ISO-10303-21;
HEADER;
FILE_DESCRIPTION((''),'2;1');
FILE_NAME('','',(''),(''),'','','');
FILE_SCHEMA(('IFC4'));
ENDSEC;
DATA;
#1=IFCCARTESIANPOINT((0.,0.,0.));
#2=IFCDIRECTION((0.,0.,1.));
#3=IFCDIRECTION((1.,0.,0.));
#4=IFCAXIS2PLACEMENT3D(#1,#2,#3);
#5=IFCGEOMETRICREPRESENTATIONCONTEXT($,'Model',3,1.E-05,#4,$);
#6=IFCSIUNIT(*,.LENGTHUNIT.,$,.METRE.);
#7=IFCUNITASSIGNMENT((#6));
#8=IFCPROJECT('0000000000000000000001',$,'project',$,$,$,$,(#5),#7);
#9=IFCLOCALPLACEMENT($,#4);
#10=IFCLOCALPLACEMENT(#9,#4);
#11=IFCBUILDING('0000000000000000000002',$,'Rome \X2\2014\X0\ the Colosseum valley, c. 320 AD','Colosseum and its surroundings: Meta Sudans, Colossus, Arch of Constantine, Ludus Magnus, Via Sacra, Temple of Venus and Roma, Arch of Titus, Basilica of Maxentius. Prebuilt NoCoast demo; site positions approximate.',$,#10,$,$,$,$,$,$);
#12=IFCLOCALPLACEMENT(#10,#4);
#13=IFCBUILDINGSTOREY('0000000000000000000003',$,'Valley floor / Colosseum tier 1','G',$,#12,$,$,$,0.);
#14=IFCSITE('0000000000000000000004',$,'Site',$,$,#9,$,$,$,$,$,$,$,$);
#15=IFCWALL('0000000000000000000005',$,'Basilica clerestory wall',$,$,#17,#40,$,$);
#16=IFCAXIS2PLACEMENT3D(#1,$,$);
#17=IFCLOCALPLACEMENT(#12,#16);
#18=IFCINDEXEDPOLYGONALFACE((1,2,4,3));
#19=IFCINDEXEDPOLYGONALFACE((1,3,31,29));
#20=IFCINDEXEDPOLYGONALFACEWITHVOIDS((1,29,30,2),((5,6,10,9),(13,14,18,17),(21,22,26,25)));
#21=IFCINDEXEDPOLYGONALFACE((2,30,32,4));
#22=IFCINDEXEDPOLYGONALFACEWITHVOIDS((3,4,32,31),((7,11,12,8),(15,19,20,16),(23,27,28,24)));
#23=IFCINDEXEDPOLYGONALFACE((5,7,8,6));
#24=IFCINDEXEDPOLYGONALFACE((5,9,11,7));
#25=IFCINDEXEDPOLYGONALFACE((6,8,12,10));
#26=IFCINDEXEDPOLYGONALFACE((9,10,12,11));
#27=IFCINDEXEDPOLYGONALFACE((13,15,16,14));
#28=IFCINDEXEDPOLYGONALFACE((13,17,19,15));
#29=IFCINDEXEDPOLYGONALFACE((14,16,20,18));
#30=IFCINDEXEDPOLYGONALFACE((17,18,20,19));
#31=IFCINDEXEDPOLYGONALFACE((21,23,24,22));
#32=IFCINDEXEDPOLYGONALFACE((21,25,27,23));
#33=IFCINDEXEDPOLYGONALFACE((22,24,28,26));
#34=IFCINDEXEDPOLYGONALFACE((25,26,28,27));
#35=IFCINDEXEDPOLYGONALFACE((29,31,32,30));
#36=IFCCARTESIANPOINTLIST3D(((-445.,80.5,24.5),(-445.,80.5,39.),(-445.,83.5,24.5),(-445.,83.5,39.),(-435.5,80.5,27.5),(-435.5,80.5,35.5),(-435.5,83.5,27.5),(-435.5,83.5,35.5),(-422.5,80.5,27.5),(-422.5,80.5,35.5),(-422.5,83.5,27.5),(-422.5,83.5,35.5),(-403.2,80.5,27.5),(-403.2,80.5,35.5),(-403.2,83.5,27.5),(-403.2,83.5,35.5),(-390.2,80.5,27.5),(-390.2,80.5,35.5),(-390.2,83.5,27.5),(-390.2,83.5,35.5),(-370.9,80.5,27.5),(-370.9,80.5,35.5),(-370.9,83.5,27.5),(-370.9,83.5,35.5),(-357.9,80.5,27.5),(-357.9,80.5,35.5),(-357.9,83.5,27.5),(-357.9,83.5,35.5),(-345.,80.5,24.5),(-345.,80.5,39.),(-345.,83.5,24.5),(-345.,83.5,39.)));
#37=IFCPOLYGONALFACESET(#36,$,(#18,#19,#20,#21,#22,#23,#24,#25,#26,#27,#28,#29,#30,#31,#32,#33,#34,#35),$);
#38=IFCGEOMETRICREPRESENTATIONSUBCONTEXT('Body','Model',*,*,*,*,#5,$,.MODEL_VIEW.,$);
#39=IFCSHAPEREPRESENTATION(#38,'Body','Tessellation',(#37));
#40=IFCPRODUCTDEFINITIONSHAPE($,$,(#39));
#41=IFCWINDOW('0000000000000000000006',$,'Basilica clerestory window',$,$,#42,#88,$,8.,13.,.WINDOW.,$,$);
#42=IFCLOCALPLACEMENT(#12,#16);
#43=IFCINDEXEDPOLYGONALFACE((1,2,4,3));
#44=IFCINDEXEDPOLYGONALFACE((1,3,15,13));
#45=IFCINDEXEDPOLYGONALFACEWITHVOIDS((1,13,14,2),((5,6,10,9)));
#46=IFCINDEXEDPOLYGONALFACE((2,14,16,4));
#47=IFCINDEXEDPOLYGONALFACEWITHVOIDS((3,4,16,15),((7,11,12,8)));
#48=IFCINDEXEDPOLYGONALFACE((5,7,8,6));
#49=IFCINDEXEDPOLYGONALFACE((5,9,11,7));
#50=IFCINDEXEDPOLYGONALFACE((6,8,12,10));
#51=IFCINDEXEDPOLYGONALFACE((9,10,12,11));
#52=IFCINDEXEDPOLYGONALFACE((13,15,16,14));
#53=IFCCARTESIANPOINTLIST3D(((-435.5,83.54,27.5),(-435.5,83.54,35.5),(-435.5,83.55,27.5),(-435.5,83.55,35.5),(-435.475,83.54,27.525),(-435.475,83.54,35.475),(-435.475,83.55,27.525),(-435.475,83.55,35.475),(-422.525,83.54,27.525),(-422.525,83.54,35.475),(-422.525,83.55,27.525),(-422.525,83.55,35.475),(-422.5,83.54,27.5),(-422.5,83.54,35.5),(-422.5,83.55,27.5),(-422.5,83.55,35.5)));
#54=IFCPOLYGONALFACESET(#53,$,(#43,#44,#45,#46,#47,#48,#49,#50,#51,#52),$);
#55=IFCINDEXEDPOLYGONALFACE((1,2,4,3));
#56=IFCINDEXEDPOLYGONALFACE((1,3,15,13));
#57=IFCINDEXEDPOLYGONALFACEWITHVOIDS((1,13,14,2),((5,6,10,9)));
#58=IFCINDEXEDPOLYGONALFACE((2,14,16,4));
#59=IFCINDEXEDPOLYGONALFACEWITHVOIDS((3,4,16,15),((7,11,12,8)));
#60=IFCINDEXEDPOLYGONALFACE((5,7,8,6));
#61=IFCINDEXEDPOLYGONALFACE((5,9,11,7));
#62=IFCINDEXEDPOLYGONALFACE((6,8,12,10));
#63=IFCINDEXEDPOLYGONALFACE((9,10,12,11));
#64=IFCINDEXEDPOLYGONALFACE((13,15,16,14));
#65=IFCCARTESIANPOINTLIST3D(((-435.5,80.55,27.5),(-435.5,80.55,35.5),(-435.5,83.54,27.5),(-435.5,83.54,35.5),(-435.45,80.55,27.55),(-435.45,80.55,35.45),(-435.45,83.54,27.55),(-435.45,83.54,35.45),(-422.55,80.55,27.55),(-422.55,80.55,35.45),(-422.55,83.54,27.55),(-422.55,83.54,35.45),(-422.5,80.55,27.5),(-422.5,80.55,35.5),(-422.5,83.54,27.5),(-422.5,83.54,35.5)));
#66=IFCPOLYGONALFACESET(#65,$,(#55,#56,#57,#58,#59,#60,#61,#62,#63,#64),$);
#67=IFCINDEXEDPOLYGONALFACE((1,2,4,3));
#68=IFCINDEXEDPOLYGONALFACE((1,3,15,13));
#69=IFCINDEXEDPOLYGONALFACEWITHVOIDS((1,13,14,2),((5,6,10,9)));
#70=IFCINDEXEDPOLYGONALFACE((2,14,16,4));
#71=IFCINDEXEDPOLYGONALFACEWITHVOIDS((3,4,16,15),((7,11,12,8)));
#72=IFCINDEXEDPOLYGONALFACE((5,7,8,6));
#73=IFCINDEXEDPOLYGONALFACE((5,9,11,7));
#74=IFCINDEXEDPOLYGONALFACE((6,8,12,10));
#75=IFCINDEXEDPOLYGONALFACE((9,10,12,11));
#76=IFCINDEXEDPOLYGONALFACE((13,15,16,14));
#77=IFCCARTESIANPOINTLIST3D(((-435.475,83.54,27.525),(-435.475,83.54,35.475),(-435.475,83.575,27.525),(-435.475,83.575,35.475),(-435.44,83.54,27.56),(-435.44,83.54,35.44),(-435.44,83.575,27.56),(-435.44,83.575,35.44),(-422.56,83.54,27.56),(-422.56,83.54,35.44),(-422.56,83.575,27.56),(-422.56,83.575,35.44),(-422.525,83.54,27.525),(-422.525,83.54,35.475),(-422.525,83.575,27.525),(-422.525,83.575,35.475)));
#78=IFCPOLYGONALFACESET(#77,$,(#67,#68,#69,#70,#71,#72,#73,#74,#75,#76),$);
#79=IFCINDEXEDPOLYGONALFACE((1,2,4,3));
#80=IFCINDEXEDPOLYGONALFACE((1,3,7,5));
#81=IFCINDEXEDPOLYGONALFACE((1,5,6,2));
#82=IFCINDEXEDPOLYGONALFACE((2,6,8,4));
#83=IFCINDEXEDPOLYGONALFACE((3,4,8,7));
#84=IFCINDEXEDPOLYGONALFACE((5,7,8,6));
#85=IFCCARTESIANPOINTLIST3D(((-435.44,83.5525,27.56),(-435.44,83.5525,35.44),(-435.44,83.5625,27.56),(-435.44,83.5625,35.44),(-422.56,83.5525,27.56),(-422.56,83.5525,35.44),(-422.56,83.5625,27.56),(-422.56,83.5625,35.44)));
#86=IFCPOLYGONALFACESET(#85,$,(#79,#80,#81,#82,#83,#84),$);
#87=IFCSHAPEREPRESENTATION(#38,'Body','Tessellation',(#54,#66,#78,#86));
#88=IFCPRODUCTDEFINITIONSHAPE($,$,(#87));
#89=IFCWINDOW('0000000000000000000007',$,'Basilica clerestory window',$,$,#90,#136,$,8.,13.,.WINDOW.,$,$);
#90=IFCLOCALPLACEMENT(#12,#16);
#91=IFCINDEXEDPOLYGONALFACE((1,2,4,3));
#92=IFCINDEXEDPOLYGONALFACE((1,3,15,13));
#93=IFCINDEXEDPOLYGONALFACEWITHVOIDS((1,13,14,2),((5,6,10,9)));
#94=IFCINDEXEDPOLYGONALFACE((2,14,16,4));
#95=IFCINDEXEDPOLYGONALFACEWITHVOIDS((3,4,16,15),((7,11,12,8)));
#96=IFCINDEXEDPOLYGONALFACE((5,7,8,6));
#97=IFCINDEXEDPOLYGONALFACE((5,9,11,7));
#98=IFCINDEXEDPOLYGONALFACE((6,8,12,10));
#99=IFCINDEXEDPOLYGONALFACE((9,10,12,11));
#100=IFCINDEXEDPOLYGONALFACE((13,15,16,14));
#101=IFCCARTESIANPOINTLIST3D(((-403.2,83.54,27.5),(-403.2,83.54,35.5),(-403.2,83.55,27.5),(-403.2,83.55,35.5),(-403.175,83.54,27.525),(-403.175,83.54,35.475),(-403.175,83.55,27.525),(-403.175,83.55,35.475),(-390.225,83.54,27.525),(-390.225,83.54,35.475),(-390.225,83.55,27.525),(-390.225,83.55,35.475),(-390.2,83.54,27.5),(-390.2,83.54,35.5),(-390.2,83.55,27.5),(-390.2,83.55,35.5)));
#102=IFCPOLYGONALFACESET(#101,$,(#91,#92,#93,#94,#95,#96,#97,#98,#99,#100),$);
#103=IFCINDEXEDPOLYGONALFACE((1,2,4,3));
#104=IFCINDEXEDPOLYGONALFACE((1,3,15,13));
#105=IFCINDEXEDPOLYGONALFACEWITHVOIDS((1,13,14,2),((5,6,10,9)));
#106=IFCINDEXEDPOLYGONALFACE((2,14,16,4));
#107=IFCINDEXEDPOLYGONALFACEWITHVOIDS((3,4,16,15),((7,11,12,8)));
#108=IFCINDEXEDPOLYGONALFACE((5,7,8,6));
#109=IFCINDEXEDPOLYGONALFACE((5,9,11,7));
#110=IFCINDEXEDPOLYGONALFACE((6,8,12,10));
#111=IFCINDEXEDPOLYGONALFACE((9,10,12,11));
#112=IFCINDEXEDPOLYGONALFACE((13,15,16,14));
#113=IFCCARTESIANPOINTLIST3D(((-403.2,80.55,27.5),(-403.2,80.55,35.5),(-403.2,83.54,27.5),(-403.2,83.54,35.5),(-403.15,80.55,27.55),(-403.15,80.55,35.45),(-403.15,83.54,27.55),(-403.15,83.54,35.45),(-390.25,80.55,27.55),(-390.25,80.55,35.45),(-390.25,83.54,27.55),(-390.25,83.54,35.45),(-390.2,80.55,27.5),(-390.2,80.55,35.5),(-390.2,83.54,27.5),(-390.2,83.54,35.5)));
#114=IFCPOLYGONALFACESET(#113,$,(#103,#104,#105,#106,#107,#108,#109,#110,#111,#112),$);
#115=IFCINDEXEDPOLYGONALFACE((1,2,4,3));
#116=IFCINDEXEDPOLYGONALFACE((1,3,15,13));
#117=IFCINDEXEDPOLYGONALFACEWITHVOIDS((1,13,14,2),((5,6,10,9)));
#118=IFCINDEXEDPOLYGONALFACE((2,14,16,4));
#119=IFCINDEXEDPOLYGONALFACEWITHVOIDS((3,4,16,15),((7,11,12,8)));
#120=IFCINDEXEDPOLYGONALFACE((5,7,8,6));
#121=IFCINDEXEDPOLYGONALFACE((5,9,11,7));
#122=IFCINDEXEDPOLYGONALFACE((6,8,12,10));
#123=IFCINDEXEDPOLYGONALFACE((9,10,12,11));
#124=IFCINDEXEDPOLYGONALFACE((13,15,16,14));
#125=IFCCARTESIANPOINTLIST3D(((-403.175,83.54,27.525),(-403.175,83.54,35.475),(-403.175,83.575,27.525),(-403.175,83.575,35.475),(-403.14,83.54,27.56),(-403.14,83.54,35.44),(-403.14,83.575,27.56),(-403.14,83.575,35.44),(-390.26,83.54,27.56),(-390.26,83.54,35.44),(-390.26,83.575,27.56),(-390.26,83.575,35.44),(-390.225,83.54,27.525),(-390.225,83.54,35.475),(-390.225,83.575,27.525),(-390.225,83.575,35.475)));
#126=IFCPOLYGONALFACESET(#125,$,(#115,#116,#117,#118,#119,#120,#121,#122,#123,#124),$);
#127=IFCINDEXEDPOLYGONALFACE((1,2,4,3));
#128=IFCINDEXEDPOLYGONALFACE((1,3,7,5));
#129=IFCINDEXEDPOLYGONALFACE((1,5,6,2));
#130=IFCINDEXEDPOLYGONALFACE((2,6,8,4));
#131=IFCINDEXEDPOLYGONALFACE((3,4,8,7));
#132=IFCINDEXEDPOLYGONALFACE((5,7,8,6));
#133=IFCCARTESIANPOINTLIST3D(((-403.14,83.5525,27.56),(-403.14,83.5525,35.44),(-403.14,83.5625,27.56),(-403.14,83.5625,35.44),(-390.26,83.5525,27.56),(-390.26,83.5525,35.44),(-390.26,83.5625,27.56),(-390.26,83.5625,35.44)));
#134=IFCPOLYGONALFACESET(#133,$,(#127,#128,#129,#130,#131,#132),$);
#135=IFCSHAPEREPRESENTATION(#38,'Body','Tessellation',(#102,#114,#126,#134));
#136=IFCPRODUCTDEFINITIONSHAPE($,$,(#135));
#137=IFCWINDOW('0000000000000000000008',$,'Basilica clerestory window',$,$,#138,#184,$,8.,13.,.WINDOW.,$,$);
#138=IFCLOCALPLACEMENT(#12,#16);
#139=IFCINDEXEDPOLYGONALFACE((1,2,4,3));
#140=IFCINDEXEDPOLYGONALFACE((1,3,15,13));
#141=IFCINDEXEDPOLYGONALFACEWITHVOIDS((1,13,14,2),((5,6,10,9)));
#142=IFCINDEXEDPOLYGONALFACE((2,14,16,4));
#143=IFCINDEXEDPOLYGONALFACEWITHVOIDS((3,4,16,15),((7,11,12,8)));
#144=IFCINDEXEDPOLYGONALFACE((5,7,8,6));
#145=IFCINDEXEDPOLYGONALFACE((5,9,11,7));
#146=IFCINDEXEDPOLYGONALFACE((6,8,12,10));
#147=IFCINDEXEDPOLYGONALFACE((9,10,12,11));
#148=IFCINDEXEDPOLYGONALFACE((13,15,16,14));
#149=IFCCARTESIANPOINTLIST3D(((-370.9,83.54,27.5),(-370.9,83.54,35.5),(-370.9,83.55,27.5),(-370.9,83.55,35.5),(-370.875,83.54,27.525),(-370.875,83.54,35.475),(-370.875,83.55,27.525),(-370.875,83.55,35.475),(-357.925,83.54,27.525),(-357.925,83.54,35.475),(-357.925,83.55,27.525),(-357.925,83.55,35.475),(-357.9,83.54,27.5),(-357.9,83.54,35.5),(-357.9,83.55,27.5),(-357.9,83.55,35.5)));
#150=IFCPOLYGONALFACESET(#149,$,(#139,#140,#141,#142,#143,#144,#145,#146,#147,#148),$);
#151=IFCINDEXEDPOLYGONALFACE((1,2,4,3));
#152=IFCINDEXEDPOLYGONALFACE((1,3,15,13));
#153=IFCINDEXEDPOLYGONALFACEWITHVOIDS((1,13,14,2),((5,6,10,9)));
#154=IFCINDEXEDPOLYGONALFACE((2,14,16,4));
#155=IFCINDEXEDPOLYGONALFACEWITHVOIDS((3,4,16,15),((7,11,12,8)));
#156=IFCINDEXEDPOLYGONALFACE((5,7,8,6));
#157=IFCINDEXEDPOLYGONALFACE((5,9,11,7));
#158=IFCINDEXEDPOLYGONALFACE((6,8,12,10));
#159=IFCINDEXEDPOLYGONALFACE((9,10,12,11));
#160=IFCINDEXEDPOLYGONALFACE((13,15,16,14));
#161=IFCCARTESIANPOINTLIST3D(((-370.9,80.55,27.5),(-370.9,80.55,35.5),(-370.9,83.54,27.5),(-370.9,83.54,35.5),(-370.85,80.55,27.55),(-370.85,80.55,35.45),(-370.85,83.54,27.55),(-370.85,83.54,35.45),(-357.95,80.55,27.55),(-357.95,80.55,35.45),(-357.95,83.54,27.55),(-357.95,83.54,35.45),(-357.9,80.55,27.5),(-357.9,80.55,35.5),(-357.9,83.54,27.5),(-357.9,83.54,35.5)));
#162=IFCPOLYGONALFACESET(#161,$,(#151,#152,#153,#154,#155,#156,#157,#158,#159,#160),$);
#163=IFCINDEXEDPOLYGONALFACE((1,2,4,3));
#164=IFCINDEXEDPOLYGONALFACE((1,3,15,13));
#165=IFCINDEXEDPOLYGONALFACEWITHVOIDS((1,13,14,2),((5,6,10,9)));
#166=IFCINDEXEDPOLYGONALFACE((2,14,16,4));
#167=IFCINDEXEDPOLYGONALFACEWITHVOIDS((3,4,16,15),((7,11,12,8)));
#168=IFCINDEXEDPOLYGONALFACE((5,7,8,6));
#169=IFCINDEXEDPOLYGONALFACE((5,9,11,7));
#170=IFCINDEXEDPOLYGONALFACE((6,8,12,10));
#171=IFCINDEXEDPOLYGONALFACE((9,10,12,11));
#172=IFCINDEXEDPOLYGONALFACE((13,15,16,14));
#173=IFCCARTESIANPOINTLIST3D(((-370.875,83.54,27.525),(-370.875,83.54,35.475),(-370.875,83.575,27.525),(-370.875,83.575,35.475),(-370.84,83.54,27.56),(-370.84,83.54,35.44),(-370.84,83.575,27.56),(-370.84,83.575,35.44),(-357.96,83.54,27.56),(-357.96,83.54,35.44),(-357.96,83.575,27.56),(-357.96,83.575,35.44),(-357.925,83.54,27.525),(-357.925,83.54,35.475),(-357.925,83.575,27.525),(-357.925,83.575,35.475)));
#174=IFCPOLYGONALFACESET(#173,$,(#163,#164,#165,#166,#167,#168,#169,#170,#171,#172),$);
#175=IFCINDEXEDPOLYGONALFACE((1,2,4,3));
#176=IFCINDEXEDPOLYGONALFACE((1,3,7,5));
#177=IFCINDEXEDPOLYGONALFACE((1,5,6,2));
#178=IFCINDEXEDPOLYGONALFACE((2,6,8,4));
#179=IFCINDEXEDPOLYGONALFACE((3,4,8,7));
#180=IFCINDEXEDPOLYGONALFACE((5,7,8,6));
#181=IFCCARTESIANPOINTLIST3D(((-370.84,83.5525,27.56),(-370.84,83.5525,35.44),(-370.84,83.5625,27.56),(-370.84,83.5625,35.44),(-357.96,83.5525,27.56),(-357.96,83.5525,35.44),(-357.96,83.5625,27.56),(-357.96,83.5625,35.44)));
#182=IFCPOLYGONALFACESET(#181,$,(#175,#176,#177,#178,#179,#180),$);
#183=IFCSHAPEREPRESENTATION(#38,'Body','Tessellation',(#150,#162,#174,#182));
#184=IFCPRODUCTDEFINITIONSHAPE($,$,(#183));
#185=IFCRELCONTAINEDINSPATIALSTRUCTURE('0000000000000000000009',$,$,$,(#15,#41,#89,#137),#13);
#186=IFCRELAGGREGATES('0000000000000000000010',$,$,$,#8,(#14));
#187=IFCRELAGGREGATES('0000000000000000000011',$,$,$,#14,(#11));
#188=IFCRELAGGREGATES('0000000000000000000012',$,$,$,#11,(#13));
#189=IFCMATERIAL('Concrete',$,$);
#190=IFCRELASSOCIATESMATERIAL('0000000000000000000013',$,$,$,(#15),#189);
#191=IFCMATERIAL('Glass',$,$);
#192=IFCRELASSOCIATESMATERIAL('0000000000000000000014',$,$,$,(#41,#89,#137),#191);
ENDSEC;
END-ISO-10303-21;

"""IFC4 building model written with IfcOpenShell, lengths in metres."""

from ifc_helpers import new_model, si_unit, frame, origin_with_axes, place, context, subcontext, project, spatial, line, indexed_curve, outline, extrude, material, element, fill, save


model = new_model("IFC4")

# Units and contexts
model_context = context("Model", 3, precision=1e-05, world=origin_with_axes())
body_context = subcontext(model_context, "Body", "Model", "MODEL_VIEW")
ifc_project = project(units=[si_unit("LENGTHUNIT", "METRE")], contexts=[model_context])

# Site, building, storey
site_placement = place(None, origin_with_axes())
site = spatial("IfcSite", under=ifc_project, at=site_placement, Name="Site")
building_placement = place(site_placement, origin_with_axes())
building = spatial("IfcBuilding", under=site, at=building_placement, Name="Rome — the Colosseum valley, c. 320 AD", Description="Colosseum and its surroundings: Meta Sudans, Colossus, Arch of Constantine, Ludus Magnus, Via Sacra, Temple of Venus and Roma, Arch of Titus, Basilica of Maxentius. Prebuilt NoCoast demo; site positions approximate.")
storey_placement = place(building_placement, origin_with_axes())
storey = spatial("IfcBuildingStorey", under=building, at=storey_placement, Name="Valley floor / Colosseum tier 1", Description="G", Elevation=0.0)

# Shared definitions
ifc_material_1 = material(Name="Concrete")

# Wall, openings, windows
wall_1_placement = place(storey_placement, frame((-445.0, 82.0, 24.5), z_axis=(0.0, 0.0, 1.0), x_axis=(1.0, 0.0, 0.0)))
wall_1 = element("IfcWall", 1, at=wall_1_placement, inside=storey, material=ifc_material_1, Name="Basilica clerestory wall", context=body_context, shape_type="SweptSolid", body=[
    extrude(outline(indexed_curve([(0.0, 0.0), (0.0, 3.0), (100.0, 3.0), (100.0, 0.0), (0.0, 0.0)], self_intersect=False)), frame((0.0, -1.5, 0.0), z_axis=(0.0, 0.0, 1.0), x_axis=(1.0, 0.0, 0.0)), (0.0, 0.0, 1.0), 14.5),
])
opening_1_placement = place(wall_1_placement, frame((9.5, -1.55, 3.0), z_axis=(0.0, 0.0, 1.0), x_axis=(1.0, 0.0, 0.0)))
opening_1 = element("IfcOpeningElement", 2, at=opening_1_placement, cuts=wall_1, context=body_context, shape_type="SweptSolid", body=[
    extrude(outline(indexed_curve([(0.0, 0.0), (0.0, 3.1), (13.0, 3.1), (13.0, 0.0), (0.0, 0.0)], self_intersect=False)), origin_with_axes(), (0.0, 0.0, 1.0), 8.0),
])
opening_2_placement = place(wall_1_placement, frame((41.8, -1.55, 3.0), z_axis=(0.0, 0.0, 1.0), x_axis=(1.0, 0.0, 0.0)))
opening_2 = element("IfcOpeningElement", 3, at=opening_2_placement, cuts=wall_1, context=body_context, shape_type="SweptSolid", body=[
    extrude(outline(indexed_curve([(0.0, 0.0), (0.0, 3.1), (13.0, 3.1), (13.0, 0.0), (0.0, 0.0)], self_intersect=False)), origin_with_axes(), (0.0, 0.0, 1.0), 8.0),
])
opening_3_placement = place(wall_1_placement, frame((74.1, -1.55, 3.0), z_axis=(0.0, 0.0, 1.0), x_axis=(1.0, 0.0, 0.0)))
opening_3 = element("IfcOpeningElement", 4, at=opening_3_placement, cuts=wall_1, context=body_context, shape_type="SweptSolid", body=[
    extrude(outline(indexed_curve([(0.0, 0.0), (0.0, 3.1), (13.0, 3.1), (13.0, 0.0), (0.0, 0.0)], self_intersect=False)), origin_with_axes(), (0.0, 0.0, 1.0), 8.0),
])
ifc_material_2 = material(Name="Glass")
window_1_placement = place(storey_placement, frame((-435.5, 80.5, 27.5), z_axis=(0.0, 0.0, 1.0), x_axis=(1.0, 0.0, 0.0)))
window_1 = element("IfcWindow", 5, at=window_1_placement, inside=storey, material=ifc_material_2, Name="Basilica clerestory window", OverallHeight=8.0, OverallWidth=13.0, PredefinedType="WINDOW", context=body_context, shape_type="SweptSolid", body=[
    extrude(outline(indexed_curve([(0.0, 0.0), (13.0, 0.0), (13.0, 8.0), (0.0, 8.0)], segments=[line(1, 2, 3, 4, 1)]), holes=[indexed_curve([(0.025, 0.025), (12.975, 0.025), (12.975, 7.975), (0.025, 7.975)], segments=[line(1, 2, 3, 4, 1)])]), frame((0.0, 3.04, 0.0), z_axis=(0.0, -1.0, 0.0), x_axis=(1.0, 0.0, 0.0)), (0.0, 0.0, -1.0), 0.01),
    extrude(outline(indexed_curve([(0.0, 0.0), (13.0, 0.0), (13.0, 8.0), (0.0, 8.0)], segments=[line(1, 2, 3, 4, 1)]), holes=[indexed_curve([(0.05, 0.05), (12.95, 0.05), (12.95, 7.95), (0.05, 7.95)], segments=[line(1, 2, 3, 4, 1)])]), frame((0.0, 0.05, 0.0), z_axis=(0.0, -1.0, 0.0), x_axis=(1.0, 0.0, 0.0)), (0.0, 0.0, -1.0), 2.99),
    extrude(outline(indexed_curve([(0.0, 0.0), (12.95, 0.0), (12.95, 7.95), (0.0, 7.95)], segments=[line(1, 2, 3, 4, 1)]), holes=[indexed_curve([(0.035, 0.035), (12.915, 0.035), (12.915, 7.915), (0.035, 7.915)], segments=[line(1, 2, 3, 4, 1)])]), frame((0.025, 3.04, 0.025), z_axis=(0.0, -1.0, 0.0), x_axis=(1.0, 0.0, 0.0)), (0.0, 0.0, -1.0), 0.035),
    extrude(outline(indexed_curve([(0.035, 0.035), (12.915, 0.035), (12.915, 7.915), (0.035, 7.915)], segments=[line(1, 2, 3, 4, 1)])), frame((0.025, 3.0525, 0.025), z_axis=(0.0, -1.0, 0.0), x_axis=(1.0, 0.0, 0.0)), (0.0, 0.0, -1.0), 0.01),
])
fill(opening_1, window_1)
window_2_placement = place(storey_placement, frame((-403.2, 80.5, 27.5), z_axis=(0.0, 0.0, 1.0), x_axis=(1.0, 0.0, 0.0)))
window_2 = element("IfcWindow", 6, at=window_2_placement, inside=storey, material=ifc_material_2, Name="Basilica clerestory window", OverallHeight=8.0, OverallWidth=13.0, PredefinedType="WINDOW", context=body_context, shape_type="SweptSolid", body=[
    extrude(outline(indexed_curve([(0.0, 0.0), (13.0, 0.0), (13.0, 8.0), (0.0, 8.0)], segments=[line(1, 2, 3, 4, 1)]), holes=[indexed_curve([(0.025, 0.025), (12.975, 0.025), (12.975, 7.975), (0.025, 7.975)], segments=[line(1, 2, 3, 4, 1)])]), frame((0.0, 3.04, 0.0), z_axis=(0.0, -1.0, 0.0), x_axis=(1.0, 0.0, 0.0)), (0.0, 0.0, -1.0), 0.01),
    extrude(outline(indexed_curve([(0.0, 0.0), (13.0, 0.0), (13.0, 8.0), (0.0, 8.0)], segments=[line(1, 2, 3, 4, 1)]), holes=[indexed_curve([(0.05, 0.05), (12.95, 0.05), (12.95, 7.95), (0.05, 7.95)], segments=[line(1, 2, 3, 4, 1)])]), frame((0.0, 0.05, 0.0), z_axis=(0.0, -1.0, 0.0), x_axis=(1.0, 0.0, 0.0)), (0.0, 0.0, -1.0), 2.99),
    extrude(outline(indexed_curve([(0.0, 0.0), (12.95, 0.0), (12.95, 7.95), (0.0, 7.95)], segments=[line(1, 2, 3, 4, 1)]), holes=[indexed_curve([(0.035, 0.035), (12.915, 0.035), (12.915, 7.915), (0.035, 7.915)], segments=[line(1, 2, 3, 4, 1)])]), frame((0.025, 3.04, 0.025), z_axis=(0.0, -1.0, 0.0), x_axis=(1.0, 0.0, 0.0)), (0.0, 0.0, -1.0), 0.035),
    extrude(outline(indexed_curve([(0.035, 0.035), (12.915, 0.035), (12.915, 7.915), (0.035, 7.915)], segments=[line(1, 2, 3, 4, 1)])), frame((0.025, 3.0525, 0.025), z_axis=(0.0, -1.0, 0.0), x_axis=(1.0, 0.0, 0.0)), (0.0, 0.0, -1.0), 0.01),
])
fill(opening_2, window_2)
window_3_placement = place(storey_placement, frame((-370.9, 80.5, 27.5), z_axis=(0.0, 0.0, 1.0), x_axis=(1.0, 0.0, 0.0)))
window_3 = element("IfcWindow", 7, at=window_3_placement, inside=storey, material=ifc_material_2, Name="Basilica clerestory window", OverallHeight=8.0, OverallWidth=13.0, PredefinedType="WINDOW", context=body_context, shape_type="SweptSolid", body=[
    extrude(outline(indexed_curve([(0.0, 0.0), (13.0, 0.0), (13.0, 8.0), (0.0, 8.0)], segments=[line(1, 2, 3, 4, 1)]), holes=[indexed_curve([(0.025, 0.025), (12.975, 0.025), (12.975, 7.975), (0.025, 7.975)], segments=[line(1, 2, 3, 4, 1)])]), frame((0.0, 3.04, 0.0), z_axis=(0.0, -1.0, 0.0), x_axis=(1.0, 0.0, 0.0)), (0.0, 0.0, -1.0), 0.01),
    extrude(outline(indexed_curve([(0.0, 0.0), (13.0, 0.0), (13.0, 8.0), (0.0, 8.0)], segments=[line(1, 2, 3, 4, 1)]), holes=[indexed_curve([(0.05, 0.05), (12.95, 0.05), (12.95, 7.95), (0.05, 7.95)], segments=[line(1, 2, 3, 4, 1)])]), frame((0.0, 0.05, 0.0), z_axis=(0.0, -1.0, 0.0), x_axis=(1.0, 0.0, 0.0)), (0.0, 0.0, -1.0), 2.99),
    extrude(outline(indexed_curve([(0.0, 0.0), (12.95, 0.0), (12.95, 7.95), (0.0, 7.95)], segments=[line(1, 2, 3, 4, 1)]), holes=[indexed_curve([(0.035, 0.035), (12.915, 0.035), (12.915, 7.915), (0.035, 7.915)], segments=[line(1, 2, 3, 4, 1)])]), frame((0.025, 3.04, 0.025), z_axis=(0.0, -1.0, 0.0), x_axis=(1.0, 0.0, 0.0)), (0.0, 0.0, -1.0), 0.035),
    extrude(outline(indexed_curve([(0.035, 0.035), (12.915, 0.035), (12.915, 7.915), (0.035, 7.915)], segments=[line(1, 2, 3, 4, 1)])), frame((0.025, 3.0525, 0.025), z_axis=(0.0, -1.0, 0.0), x_axis=(1.0, 0.0, 0.0)), (0.0, 0.0, -1.0), 0.01),
])
fill(opening_3, window_3)

save(model, "model.ifc")
